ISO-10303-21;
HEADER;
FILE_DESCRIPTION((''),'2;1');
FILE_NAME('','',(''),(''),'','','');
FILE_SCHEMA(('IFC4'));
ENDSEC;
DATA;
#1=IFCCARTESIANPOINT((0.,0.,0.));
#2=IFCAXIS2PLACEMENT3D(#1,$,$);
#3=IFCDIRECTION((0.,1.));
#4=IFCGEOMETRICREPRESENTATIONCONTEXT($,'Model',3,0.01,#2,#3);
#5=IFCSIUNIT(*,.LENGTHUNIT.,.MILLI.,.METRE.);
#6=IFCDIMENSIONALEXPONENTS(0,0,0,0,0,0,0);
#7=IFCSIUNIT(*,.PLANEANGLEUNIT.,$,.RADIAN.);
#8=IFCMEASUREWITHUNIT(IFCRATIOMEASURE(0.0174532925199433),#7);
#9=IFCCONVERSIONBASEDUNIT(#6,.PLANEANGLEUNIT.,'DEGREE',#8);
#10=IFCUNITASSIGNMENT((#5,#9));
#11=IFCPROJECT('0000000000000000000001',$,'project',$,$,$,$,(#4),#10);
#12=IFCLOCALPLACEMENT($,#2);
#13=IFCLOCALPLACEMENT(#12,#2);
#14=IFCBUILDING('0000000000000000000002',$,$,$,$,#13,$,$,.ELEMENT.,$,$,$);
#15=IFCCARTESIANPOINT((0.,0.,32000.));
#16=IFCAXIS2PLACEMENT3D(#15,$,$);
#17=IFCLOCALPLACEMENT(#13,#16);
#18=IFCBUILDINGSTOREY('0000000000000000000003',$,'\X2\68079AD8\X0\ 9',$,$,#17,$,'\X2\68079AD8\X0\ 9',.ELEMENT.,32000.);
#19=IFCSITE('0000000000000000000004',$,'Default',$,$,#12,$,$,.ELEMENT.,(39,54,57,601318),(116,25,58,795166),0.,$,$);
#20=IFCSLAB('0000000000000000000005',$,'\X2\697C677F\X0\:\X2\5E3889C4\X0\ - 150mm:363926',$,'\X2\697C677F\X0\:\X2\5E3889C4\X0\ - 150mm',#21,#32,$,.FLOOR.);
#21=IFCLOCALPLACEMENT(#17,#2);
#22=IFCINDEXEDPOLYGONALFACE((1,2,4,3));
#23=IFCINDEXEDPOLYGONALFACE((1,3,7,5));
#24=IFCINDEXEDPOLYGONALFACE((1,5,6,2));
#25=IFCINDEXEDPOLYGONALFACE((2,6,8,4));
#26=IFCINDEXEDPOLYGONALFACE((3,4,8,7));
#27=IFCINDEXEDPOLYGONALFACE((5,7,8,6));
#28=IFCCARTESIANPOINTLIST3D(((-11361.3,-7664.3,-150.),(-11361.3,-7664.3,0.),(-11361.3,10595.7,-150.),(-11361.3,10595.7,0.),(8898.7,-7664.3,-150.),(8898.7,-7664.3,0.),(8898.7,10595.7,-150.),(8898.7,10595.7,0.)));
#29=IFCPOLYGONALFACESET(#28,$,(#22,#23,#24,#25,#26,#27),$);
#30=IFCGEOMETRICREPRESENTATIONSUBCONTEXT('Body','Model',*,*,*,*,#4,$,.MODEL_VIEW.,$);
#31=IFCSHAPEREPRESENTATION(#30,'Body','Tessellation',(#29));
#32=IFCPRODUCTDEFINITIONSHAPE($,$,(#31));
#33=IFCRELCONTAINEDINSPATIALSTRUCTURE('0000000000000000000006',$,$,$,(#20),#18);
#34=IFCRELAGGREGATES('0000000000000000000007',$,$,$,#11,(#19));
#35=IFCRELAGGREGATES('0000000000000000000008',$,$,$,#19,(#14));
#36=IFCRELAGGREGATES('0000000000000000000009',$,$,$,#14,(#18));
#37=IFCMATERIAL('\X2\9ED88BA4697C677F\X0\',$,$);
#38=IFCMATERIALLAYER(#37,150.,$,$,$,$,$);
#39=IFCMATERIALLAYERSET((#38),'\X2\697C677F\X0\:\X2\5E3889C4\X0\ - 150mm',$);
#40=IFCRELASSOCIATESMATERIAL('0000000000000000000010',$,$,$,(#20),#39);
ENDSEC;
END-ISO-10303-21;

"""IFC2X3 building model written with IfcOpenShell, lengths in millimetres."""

from ifc_helpers import new_model, entity, si_unit, converted_unit, direction, frame, frame_2d, origin, place, context, subcontext, project, spatial, rectangle, extrude, material, layer, layer_set, layer_usage, element, save


model = new_model("IFC2X3")

# Units and contexts
model_context = context("Model", 3, precision=0.01, world=origin(), true_north=direction((0.0, 1.0)))
body_context = subcontext(model_context, "Body", "Model", "MODEL_VIEW")
ifc_project = project(units=[si_unit("LENGTHUNIT", "METRE", prefix="MILLI"), converted_unit("PLANEANGLEUNIT", "DEGREE", entity("IfcRatioMeasure", 0.0174532925199433), si_unit("PLANEANGLEUNIT", "RADIAN"), dimensions=[0, 0, 0, 0, 0, 0, 0])], contexts=[model_context])

# Site, building, storey
site_placement = place(None, origin())
site = spatial("IfcSite", under=ifc_project, at=site_placement, Name="Default", CompositionType="ELEMENT", RefLatitude=(39, 54, 57, 601318), RefLongitude=(116, 25, 58, 795166), RefElevation=0.0)
building_placement = place(site_placement, origin())
building = spatial("IfcBuilding", under=site, at=building_placement, CompositionType="ELEMENT")
storey_placement = place(building_placement, frame((0.0, 0.0, 32000.0)))
storey = spatial("IfcBuildingStorey", under=building, at=storey_placement, Name="标高 9", LongName="标高 9", CompositionType="ELEMENT", Elevation=32000.0)

# Slab
ifc_material_1 = material(Name="默认楼板")
ifc_layer = layer(ifc_material_1, 150.0)
ifc_layer_set = layer_set([ifc_layer], Name="楼板:常规 - 150mm")
ifc_layer_usage = layer_usage(ifc_layer_set, "AXIS3", "POSITIVE", 0.0)
slab_placement = place(storey_placement, origin())
element("IfcSlab", 1, at=slab_placement, inside=storey, material=ifc_layer_usage, Name="楼板:常规 - 150mm:363926", ObjectType="楼板:常规 - 150mm", PredefinedType="FLOOR", context=body_context, shape_type="SweptSolid", body=[
    extrude(rectangle(XDim=18260.0, YDim=20260.0, at=frame_2d((0.0, 0.0), x_axis=(1.0, 0.0))), frame((-1231.3, 1465.7, 0.0), z_axis=(0.0, 0.0, -1.0), x_axis=(0.0, 1.0, 0.0)), (0.0, 0.0, 1.0), 150.0),
])

save(model, "model.ifc")
